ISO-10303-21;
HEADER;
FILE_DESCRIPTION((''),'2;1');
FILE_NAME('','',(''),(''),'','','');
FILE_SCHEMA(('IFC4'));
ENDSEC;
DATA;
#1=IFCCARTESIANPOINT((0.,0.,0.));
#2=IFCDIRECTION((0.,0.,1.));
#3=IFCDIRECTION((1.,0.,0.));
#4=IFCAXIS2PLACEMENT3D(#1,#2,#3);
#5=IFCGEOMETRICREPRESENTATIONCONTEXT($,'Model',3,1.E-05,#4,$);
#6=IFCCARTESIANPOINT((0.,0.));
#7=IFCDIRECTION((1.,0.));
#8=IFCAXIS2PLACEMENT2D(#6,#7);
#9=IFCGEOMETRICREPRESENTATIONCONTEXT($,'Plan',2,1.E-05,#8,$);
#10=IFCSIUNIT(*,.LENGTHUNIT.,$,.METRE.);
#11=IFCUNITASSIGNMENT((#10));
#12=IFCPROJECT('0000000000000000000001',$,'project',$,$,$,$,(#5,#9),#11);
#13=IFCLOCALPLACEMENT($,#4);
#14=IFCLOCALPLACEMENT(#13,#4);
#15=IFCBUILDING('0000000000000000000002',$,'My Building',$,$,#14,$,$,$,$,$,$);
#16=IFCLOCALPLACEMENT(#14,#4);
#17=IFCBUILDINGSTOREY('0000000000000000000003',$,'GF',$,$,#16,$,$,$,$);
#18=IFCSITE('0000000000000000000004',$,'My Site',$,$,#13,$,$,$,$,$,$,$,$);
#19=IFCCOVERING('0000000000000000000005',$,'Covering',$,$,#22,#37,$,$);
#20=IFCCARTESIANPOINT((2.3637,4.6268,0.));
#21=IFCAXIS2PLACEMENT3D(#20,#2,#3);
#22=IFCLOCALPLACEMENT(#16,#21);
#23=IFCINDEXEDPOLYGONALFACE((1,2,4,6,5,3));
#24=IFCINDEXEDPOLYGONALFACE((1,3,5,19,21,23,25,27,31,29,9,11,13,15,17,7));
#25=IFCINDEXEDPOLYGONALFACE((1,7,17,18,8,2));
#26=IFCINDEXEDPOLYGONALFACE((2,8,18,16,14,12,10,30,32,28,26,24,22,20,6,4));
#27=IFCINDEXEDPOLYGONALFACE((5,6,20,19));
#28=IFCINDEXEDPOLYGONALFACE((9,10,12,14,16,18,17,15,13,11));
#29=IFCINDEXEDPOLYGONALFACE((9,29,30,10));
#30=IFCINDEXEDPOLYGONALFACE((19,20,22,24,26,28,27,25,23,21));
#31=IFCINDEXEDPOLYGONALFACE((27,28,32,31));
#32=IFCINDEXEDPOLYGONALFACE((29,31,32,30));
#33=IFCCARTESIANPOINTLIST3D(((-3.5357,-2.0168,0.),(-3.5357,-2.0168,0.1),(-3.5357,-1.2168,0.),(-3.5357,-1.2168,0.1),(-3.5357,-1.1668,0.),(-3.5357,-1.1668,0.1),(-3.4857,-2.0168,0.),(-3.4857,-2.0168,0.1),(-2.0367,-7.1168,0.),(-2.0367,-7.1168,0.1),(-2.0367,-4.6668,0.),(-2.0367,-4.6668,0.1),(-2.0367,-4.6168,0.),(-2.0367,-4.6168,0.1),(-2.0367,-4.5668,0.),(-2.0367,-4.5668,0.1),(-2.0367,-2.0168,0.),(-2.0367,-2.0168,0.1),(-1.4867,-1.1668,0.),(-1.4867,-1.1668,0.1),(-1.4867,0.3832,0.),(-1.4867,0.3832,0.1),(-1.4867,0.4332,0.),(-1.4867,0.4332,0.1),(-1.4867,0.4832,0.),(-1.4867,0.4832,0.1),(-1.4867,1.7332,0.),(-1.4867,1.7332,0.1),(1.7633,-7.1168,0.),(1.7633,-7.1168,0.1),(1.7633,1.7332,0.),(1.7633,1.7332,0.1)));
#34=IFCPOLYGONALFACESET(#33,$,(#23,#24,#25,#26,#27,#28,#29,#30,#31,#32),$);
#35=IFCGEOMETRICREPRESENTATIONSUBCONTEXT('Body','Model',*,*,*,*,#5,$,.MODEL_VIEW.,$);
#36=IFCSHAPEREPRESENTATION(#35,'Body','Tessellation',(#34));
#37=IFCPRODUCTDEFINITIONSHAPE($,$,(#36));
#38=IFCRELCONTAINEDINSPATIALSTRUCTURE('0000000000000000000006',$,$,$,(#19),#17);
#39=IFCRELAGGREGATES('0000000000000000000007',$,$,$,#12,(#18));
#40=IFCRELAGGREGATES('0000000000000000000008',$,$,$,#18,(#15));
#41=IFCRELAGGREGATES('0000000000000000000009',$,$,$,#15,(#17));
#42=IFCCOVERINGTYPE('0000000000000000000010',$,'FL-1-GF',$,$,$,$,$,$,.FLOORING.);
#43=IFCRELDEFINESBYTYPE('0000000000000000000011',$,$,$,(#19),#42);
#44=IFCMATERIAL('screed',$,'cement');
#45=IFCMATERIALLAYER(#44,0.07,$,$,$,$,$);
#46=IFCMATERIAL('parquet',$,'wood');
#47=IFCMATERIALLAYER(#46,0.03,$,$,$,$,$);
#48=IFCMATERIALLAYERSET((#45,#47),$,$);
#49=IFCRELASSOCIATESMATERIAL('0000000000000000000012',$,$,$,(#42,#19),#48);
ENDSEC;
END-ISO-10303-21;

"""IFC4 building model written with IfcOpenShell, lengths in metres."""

from ifc_helpers import new_model, si_unit, frame, origin_with_axes, origin_2d_with_axis, place, context, subcontext, project, spatial, line, indexed_curve, outline, extrude, material, layer, layer_set, layer_usage, type_object, element, save


model = new_model("IFC4")

# Units and contexts
model_context = context("Model", 3, precision=1e-05, world=origin_with_axes())
plan_context = context("Plan", 2, precision=1e-05, world=origin_2d_with_axis())
body_context_1 = subcontext(model_context, "Body", "Model", "MODEL_VIEW")
ifc_project = project(units=[si_unit("LENGTHUNIT", "METRE")], contexts=[model_context, plan_context])

# Site, building, storey
site_placement = place(None, origin_with_axes())
site = spatial("IfcSite", under=ifc_project, at=site_placement, Name="My Site")
building_placement = place(site_placement, origin_with_axes())
building = spatial("IfcBuilding", under=site, at=building_placement, Name="My Building")
storey_placement = place(building_placement, origin_with_axes())
storey = spatial("IfcBuildingStorey", under=building, at=storey_placement, Name="GF")

# Covering
ifc_material_1 = material(Name="screed", Category="cement")
ifc_layer_1 = layer(ifc_material_1, 0.07)
ifc_material_2 = material(Name="parquet", Category="wood")
ifc_layer_2 = layer(ifc_material_2, 0.03)
ifc_layer_set_1 = layer_set([ifc_layer_1, ifc_layer_2])
ifc_layer_usage_1 = layer_usage(ifc_layer_set_1, "AXIS3", "POSITIVE", 0.0)
covering_type = type_object("IfcCoveringType", Name="FL-1-GF", PredefinedType="FLOORING", material=ifc_layer_set_1)
covering_placement = place(storey_placement, frame((2.3637, 4.6268, 0.0), z_axis=(0.0, 0.0, 1.0), x_axis=(1.0, 0.0, 0.0)))
element("IfcCovering", 1, at=covering_placement, inside=storey, type_object=covering_type, material=ifc_layer_usage_1, Name="Covering", context=body_context_1, shape_type="SweptSolid", body=[
    extrude(outline(indexed_curve([(-1.4867, 1.7332), (1.7633, 1.7332), (1.7633, -7.1168), (-2.0367, -7.1168), (-2.0367, -4.6668), (-2.0367, -4.6168), (-2.0367, -4.6168), (-2.0367, -4.5668), (-2.0367, -2.0168), (-3.4857, -2.0168), (-3.5357, -2.0168), (-3.5357, -1.2168), (-3.5357, -1.1668), (-1.4867, -1.1668), (-1.4867, 0.3832), (-1.4867, 0.4332), (-1.4867, 0.4832)], segments=[line(1, 2, 3, 4, 5, 6, 7, 8, 9, 10, 11, 12, 13, 14, 15, 16, 17, 1)])), origin_with_axes(), (0.0, 0.0, 1.0), 0.1),
])

save(model, "model.ifc")
